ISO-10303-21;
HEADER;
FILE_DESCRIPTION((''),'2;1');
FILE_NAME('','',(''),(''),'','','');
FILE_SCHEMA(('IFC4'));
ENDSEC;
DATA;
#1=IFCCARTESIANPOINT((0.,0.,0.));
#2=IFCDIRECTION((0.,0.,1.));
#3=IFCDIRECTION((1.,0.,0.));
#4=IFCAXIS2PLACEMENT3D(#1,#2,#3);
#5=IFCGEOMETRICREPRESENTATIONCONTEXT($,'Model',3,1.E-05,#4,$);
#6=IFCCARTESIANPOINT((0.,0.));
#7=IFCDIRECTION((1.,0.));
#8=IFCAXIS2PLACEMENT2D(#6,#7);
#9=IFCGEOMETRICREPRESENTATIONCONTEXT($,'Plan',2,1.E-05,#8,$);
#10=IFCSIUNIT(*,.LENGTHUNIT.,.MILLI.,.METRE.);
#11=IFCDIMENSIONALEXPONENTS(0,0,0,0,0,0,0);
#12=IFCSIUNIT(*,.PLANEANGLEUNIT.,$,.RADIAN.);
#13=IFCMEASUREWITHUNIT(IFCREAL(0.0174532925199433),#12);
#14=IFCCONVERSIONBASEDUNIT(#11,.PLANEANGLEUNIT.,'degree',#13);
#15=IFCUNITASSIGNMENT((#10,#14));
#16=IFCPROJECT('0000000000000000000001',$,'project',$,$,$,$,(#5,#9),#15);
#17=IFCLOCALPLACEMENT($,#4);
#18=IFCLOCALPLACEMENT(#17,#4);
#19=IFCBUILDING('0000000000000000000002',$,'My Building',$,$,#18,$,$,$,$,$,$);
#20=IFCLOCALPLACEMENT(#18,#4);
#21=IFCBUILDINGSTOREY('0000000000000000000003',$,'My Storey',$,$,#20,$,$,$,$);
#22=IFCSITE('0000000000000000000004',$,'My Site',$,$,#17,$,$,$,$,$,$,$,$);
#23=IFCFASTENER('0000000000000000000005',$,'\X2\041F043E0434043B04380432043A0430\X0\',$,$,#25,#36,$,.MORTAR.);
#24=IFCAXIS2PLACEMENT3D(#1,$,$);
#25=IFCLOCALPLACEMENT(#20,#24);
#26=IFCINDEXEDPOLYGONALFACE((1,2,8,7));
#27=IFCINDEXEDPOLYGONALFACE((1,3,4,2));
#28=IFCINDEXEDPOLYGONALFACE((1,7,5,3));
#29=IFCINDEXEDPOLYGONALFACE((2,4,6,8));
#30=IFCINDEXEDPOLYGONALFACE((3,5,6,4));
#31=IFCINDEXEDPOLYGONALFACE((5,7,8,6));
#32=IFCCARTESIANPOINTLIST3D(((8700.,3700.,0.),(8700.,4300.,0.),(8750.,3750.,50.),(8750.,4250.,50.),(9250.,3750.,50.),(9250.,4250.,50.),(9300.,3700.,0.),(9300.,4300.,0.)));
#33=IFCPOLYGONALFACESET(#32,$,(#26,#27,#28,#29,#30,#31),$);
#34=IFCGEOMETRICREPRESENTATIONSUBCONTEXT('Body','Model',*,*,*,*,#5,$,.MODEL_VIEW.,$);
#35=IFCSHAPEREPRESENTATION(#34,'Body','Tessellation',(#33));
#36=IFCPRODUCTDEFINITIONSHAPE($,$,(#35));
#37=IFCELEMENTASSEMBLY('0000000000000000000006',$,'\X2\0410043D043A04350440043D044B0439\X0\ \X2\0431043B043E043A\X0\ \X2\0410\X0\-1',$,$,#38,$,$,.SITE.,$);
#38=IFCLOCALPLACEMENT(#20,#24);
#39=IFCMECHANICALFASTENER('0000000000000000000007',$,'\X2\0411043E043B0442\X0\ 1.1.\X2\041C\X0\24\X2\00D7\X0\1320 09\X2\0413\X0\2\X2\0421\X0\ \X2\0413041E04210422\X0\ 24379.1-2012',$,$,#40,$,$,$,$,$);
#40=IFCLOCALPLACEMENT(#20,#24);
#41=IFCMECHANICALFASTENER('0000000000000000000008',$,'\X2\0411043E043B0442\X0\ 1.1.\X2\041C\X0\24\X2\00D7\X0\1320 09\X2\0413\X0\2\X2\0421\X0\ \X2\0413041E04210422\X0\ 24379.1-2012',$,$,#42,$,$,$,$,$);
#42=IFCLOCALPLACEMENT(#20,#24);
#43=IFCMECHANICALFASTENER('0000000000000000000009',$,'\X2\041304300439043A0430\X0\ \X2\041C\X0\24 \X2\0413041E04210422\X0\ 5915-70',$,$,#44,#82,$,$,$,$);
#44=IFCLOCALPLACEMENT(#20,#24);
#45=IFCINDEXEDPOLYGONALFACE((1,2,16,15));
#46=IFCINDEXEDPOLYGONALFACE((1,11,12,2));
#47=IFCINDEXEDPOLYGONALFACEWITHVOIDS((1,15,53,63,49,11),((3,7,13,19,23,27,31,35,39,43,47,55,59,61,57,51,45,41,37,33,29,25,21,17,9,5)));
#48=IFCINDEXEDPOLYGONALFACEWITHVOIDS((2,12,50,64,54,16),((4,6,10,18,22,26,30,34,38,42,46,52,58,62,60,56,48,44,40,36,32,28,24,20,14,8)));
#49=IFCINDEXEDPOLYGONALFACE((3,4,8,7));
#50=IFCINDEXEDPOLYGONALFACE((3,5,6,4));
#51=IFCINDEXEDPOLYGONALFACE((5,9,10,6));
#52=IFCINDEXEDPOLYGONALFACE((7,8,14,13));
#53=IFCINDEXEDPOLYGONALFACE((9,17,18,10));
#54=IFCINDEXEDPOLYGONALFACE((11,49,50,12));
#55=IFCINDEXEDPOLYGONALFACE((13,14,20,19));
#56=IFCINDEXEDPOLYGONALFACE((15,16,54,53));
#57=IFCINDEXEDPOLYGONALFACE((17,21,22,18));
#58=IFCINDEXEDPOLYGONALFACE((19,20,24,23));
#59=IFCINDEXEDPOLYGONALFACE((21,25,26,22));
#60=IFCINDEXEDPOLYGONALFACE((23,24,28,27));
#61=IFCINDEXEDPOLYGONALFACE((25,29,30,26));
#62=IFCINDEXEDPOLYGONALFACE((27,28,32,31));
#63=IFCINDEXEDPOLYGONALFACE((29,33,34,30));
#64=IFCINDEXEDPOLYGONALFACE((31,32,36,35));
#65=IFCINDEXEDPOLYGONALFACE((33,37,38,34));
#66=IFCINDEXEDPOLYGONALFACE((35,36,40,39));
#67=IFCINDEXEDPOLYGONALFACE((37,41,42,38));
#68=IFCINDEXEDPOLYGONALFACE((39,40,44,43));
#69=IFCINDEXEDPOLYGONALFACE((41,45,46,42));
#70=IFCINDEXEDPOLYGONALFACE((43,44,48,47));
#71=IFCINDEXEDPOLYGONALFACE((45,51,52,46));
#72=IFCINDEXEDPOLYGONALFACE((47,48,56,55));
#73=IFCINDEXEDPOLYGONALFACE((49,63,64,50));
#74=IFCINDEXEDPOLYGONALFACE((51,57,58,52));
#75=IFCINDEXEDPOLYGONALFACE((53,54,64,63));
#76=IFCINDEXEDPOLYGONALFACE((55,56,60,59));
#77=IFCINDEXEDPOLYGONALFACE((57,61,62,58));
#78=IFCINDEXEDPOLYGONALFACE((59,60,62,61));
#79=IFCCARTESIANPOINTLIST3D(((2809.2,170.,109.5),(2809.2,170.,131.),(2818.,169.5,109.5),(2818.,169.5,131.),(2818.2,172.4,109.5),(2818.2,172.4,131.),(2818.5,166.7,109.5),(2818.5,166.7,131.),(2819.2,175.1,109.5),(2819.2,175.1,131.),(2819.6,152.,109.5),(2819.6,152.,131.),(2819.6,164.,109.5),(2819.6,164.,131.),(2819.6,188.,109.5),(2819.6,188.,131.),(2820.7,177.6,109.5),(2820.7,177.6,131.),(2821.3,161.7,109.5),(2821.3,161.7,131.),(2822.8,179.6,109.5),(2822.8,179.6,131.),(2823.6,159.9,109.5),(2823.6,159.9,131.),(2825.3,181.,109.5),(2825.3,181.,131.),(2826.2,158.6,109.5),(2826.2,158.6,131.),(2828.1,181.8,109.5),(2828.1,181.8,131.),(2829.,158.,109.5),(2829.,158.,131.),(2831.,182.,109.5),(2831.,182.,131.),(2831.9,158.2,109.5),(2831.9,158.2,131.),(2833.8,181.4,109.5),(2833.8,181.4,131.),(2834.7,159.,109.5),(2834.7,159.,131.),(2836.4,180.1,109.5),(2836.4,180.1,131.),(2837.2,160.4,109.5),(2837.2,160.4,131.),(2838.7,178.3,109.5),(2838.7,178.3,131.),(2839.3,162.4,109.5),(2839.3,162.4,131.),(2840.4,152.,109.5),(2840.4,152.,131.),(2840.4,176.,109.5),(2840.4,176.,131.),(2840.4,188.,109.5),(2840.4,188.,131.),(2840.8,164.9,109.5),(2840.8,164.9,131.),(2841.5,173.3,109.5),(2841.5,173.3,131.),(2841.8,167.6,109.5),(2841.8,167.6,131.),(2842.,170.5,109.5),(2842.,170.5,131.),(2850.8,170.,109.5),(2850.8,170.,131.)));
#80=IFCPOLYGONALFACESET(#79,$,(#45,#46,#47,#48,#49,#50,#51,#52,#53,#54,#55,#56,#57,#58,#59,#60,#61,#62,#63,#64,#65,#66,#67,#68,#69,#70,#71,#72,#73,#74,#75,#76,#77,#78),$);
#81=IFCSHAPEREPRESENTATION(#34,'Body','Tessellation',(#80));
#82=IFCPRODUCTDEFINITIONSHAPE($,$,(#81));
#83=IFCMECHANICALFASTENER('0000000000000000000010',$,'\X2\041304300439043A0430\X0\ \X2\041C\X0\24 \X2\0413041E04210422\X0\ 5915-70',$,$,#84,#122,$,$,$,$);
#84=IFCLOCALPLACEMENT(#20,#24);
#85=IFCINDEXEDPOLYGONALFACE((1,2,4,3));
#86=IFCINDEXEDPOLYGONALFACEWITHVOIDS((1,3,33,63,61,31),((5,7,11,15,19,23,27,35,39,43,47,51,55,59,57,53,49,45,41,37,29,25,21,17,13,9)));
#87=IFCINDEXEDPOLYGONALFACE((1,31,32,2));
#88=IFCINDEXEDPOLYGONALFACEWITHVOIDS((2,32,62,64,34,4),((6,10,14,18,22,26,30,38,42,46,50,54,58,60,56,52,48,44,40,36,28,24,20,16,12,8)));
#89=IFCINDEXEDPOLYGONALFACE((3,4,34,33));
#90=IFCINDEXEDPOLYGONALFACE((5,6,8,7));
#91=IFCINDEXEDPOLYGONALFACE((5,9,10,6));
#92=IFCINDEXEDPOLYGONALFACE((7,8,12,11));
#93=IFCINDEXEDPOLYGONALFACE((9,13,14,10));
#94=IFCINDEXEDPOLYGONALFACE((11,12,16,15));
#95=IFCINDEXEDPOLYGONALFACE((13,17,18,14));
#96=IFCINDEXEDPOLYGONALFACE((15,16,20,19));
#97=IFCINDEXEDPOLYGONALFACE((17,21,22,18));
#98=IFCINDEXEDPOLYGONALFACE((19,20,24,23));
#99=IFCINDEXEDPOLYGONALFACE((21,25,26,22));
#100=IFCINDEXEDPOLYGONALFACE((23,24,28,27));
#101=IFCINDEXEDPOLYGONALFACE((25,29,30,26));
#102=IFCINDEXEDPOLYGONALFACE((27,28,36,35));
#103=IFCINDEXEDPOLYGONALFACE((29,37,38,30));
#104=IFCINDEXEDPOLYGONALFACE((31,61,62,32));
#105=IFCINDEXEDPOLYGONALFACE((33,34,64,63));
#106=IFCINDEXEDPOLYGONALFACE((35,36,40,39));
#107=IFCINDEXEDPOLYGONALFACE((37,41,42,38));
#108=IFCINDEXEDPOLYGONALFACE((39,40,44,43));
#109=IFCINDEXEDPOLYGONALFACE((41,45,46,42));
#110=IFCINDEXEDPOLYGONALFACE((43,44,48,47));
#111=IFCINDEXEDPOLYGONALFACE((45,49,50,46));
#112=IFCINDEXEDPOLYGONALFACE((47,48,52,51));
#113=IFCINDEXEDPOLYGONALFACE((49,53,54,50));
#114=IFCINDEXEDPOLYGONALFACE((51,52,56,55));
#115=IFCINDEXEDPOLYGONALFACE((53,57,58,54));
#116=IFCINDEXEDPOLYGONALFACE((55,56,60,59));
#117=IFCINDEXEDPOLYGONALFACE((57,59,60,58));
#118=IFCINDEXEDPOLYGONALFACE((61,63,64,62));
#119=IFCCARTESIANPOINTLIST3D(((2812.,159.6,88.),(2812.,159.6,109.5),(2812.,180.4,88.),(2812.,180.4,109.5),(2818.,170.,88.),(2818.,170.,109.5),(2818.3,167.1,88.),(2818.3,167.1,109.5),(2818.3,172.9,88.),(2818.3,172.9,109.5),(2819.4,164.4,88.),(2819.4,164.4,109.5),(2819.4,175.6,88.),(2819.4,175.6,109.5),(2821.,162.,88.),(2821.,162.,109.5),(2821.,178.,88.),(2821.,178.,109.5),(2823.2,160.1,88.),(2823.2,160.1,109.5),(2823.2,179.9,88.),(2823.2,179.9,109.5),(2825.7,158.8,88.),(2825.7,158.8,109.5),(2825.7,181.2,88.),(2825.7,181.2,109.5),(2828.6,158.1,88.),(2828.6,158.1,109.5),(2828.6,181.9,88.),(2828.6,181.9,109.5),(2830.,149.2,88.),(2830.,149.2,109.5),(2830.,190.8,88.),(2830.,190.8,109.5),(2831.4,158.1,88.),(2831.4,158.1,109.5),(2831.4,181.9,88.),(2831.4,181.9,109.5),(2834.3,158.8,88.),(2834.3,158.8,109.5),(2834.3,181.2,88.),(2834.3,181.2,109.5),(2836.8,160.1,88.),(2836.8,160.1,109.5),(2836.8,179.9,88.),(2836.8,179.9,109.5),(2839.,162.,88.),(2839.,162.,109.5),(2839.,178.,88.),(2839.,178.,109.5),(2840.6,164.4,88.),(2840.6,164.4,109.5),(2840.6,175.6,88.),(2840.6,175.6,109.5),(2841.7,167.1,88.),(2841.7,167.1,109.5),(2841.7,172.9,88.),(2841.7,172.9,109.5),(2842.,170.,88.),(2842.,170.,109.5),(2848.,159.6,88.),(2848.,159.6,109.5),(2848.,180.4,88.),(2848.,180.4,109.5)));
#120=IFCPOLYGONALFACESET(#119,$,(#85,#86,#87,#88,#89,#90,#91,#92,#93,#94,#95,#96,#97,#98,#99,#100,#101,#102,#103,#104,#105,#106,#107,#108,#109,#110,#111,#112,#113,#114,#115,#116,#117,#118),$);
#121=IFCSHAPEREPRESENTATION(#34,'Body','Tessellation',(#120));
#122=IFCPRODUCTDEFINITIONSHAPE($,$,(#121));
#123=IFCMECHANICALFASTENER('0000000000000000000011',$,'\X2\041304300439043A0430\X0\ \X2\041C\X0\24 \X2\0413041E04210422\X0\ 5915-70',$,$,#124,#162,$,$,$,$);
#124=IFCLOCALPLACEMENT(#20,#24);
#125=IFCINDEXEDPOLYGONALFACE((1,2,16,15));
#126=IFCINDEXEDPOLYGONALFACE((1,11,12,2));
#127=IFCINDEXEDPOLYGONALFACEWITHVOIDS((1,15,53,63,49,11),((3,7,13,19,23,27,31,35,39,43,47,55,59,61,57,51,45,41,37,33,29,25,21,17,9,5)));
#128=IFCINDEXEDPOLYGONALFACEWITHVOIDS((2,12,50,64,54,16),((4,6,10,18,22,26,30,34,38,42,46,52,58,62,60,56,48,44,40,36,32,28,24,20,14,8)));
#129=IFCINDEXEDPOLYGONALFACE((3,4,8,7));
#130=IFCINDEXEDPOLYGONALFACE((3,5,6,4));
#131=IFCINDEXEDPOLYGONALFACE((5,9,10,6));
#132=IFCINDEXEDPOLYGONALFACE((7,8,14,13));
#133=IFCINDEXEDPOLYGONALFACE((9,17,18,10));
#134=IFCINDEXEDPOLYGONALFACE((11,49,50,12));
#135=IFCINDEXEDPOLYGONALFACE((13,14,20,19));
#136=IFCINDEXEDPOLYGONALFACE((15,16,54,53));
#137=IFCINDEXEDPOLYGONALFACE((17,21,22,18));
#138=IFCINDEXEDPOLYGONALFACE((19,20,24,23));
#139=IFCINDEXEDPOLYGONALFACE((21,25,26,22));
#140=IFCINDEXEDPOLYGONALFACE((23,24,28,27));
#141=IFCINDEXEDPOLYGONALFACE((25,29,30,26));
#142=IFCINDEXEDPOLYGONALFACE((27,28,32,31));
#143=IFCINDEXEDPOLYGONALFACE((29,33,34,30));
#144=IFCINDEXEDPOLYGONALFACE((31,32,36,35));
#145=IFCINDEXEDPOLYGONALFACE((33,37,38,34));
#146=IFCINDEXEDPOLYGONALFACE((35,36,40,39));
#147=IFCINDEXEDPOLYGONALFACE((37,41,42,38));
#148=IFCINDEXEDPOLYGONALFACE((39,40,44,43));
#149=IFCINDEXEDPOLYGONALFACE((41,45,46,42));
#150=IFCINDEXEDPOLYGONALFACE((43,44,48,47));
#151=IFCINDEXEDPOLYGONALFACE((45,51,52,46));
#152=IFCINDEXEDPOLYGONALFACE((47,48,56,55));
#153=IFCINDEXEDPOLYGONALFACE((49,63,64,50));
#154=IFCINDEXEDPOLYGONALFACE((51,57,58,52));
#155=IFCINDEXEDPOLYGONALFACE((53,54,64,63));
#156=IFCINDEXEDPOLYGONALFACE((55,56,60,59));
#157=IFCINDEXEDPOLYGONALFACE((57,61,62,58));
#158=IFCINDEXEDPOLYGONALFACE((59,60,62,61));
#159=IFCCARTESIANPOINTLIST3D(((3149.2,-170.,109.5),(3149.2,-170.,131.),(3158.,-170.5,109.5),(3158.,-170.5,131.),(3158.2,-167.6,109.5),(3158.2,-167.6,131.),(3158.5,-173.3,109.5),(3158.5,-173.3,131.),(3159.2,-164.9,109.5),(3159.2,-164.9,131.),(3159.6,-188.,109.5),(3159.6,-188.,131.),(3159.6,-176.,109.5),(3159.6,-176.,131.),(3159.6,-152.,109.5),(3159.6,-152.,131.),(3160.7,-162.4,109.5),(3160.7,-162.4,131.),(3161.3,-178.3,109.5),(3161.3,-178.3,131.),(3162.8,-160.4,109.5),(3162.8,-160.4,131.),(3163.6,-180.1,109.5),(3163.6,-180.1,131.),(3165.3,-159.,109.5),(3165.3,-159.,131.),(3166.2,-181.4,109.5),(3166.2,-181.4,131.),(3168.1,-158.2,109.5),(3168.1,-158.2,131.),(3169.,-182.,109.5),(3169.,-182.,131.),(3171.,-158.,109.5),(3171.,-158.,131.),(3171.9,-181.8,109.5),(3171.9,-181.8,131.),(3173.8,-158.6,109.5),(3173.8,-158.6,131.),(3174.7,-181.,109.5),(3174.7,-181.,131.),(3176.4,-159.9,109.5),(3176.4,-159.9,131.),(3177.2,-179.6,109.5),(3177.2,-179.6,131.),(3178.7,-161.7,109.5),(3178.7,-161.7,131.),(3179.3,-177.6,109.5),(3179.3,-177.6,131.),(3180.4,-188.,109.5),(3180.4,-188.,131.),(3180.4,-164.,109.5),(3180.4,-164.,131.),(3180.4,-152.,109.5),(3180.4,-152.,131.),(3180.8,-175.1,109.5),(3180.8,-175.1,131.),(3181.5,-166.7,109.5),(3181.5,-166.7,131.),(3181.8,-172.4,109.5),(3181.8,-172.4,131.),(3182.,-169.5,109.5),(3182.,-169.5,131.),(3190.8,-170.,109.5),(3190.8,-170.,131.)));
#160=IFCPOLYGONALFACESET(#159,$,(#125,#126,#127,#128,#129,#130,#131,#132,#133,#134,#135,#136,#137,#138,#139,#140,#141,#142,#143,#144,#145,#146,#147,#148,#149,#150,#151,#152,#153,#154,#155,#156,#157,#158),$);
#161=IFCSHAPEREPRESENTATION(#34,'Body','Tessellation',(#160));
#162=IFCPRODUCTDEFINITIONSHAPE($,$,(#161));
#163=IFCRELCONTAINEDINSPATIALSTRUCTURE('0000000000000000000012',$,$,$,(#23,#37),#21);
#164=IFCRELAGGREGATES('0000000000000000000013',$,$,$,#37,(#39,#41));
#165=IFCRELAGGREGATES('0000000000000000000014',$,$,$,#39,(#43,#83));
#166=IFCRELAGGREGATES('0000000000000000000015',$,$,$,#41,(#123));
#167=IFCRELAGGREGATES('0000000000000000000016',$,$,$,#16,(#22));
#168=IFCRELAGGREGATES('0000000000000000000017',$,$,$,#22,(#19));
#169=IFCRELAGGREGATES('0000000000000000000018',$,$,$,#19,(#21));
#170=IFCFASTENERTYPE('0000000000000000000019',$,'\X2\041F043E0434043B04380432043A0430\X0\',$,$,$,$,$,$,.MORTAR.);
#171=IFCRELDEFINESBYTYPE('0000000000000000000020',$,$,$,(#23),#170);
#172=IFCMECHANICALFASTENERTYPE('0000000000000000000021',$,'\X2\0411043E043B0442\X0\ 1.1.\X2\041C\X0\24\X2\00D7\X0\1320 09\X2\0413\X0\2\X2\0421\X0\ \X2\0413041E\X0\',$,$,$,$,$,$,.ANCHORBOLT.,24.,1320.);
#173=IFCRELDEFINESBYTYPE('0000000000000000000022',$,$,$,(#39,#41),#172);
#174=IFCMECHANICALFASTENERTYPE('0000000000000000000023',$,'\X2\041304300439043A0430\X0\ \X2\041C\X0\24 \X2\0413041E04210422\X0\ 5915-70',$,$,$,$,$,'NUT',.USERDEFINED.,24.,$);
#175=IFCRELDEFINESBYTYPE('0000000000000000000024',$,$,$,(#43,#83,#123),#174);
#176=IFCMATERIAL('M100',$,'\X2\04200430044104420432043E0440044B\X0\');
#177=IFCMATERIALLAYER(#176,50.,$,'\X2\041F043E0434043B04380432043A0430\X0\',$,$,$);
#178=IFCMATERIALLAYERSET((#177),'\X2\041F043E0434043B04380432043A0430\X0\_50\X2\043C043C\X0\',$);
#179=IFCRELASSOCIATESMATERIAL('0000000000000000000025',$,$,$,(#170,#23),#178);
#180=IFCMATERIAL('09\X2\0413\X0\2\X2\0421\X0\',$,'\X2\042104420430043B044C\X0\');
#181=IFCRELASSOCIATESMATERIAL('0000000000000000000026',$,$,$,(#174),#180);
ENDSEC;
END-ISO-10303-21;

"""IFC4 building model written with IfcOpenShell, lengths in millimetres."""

from ifc_helpers import new_model, entity, si_unit, converted_unit, frame, origin_with_axes, origin_2d_with_axis, place, context, subcontext, project, spatial, polyline, line, indexed_curve, outline, extrude, clip, halfspace, source, transform, mapped, material, layer, layer_set, layer_usage, type_object, type_shapes, element, aggregate, save


model = new_model("IFC4")

# Units and contexts
model_context = context("Model", 3, precision=1e-05, world=origin_with_axes())
plan_context = context("Plan", 2, precision=1e-05, world=origin_2d_with_axis())
body_context = subcontext(model_context, "Body", "Model", "MODEL_VIEW")
ifc_project = project(units=[si_unit("LENGTHUNIT", "METRE", prefix="MILLI"), converted_unit("PLANEANGLEUNIT", "degree", entity("IfcReal", 0.0174532925199433), si_unit("PLANEANGLEUNIT", "RADIAN"), dimensions=[0, 0, 0, 0, 0, 0, 0])], contexts=[model_context, plan_context])

# Site, building, storey
site_placement = place(None, origin_with_axes())
site = spatial("IfcSite", under=ifc_project, at=site_placement, Name="My Site")
building_placement = place(site_placement, origin_with_axes())
building = spatial("IfcBuilding", under=site, at=building_placement, Name="My Building")
storey_placement = place(building_placement, origin_with_axes())
storey = spatial("IfcBuildingStorey", under=building, at=storey_placement, Name="My Storey")

# Fastener
ifc_material_1 = material(Name="M100", Category="Растворы")
ifc_layer_1 = layer(ifc_material_1, 50.0, Name="Подливка")
ifc_layer_set_1 = layer_set([ifc_layer_1], Name="Подливка_50мм")
ifc_layer_usage_1 = layer_usage(ifc_layer_set_1, "AXIS3", "POSITIVE", 0.0)
fastener_type = type_object("IfcFastenerType", Name="Подливка", PredefinedType="MORTAR", material=ifc_layer_set_1)
placement = place(storey_placement, frame((3000.0, 0.0, 0.0), z_axis=(0.0, 0.0, 1.0), x_axis=(1.0, 0.0, 0.0)))
fastener_1_placement = place(storey_placement, frame((9000.0, 4000.0, 0.0), z_axis=(0.0, 0.0, 1.0), x_axis=(1.0, 0.0, 0.0)))
element("IfcFastener", 1, at=fastener_1_placement, inside=storey, type_object=fastener_type, material=ifc_layer_usage_1, Name="Подливка", PredefinedType="MORTAR", context=body_context, shape_type="Clipping", body=[
    clip(clip(clip(clip(extrude(outline(indexed_curve([(-300.0, -300.0), (300.0, -300.0), (300.0, 300.0), (-300.0, 300.0)], segments=[line(3, 2), line(2, 1), line(1, 4), line(4, 3)], self_intersect=False)), None, (0.0, 0.0, 1.0), 50.0), halfspace(frame((-53.6, 200.0, 353.6), z_axis=(0.707107, 0.0, 0.707107), x_axis=(0.707107, 0.0, -0.707107)), False)), halfspace(frame((-200.0, -53.6, 353.6), z_axis=(0.0, 0.707107, 0.707107), x_axis=(0.0, 0.707107, -0.707107)), False)), halfspace(frame((200.0, 53.6, 353.6), z_axis=(0.0, -0.707107, 0.707107), x_axis=(0.0, -0.707107, -0.707107)), False)), halfspace(frame((53.6, 200.0, 353.6), z_axis=(-0.707107, 0.0, 0.707107), x_axis=(-0.707107, 0.0, -0.707107)), False)),
])

# Element assembly, mechanical fasteners
assembly = element("IfcElementAssembly", 2, at=placement, inside=storey, Name="Анкерный блок А-1", AssemblyPlace="SITE")
mechanical_fastener_type_1 = type_object("IfcMechanicalFastenerType", Name="Болт 1.1.М24×1320 09Г2С ГО", NominalDiameter=24.0, NominalLength=1320.0, PredefinedType="ANCHORBOLT")
mechanical_fastener_1_placement = place(placement, frame((-170.0, 170.0, 0.0), z_axis=(0.0, 0.0, 1.0), x_axis=(-1.0, 0.0, 0.0)))
mechanical_fastener_1 = element("IfcMechanicalFastener", 3, at=mechanical_fastener_1_placement, type_object=mechanical_fastener_type_1, Name="Болт 1.1.М24×1320 09Г2С ГОСТ 24379.1-2012")
ifc_material_2 = material(Name="09Г2С", Category="Сталь")
mechanical_fastener_2_placement = place(placement, frame((170.0, -170.0, 0.0), z_axis=(0.0, 0.0, 1.0), x_axis=(1.0, 0.0, 0.0)))
mechanical_fastener_2 = element("IfcMechanicalFastener", 4, at=mechanical_fastener_2_placement, type_object=mechanical_fastener_type_1, Name="Болт 1.1.М24×1320 09Г2С ГОСТ 24379.1-2012")
aggregate(assembly, [mechanical_fastener_1, mechanical_fastener_2])
mechanical_fastener_type_2 = type_object("IfcMechanicalFastenerType", Name="Гайка М24 ГОСТ 5915-70", ElementType="NUT", NominalDiameter=24.0, PredefinedType="USERDEFINED", material=ifc_material_2)
shared_shape_1 = source(origin_with_axes(), body_context, "Body", "SweptSolid", [
    extrude(outline(polyline([(-10.4, -18.0), (10.4, -18.0), (20.8, 0.0), (10.4, 18.0), (-10.4, 18.0), (-20.8, 0.0), (-10.4, -18.0)]), holes=[polyline([(-8.0, 9.0), (-5.6, 10.6), (-2.9, 11.7), (0.0, 12.0), (2.9, 11.7), (5.6, 10.6), (8.0, 9.0), (9.9, 6.8), (11.2, 4.3), (11.9, 1.4), (11.9, -1.4), (11.2, -4.3), (9.9, -6.8), (8.0, -9.0), (5.6, -10.6), (2.9, -11.7), (0.0, -12.0), (-2.9, -11.7), (-5.6, -10.6), (-8.0, -9.0), (-9.9, -6.8), (-11.2, -4.3), (-11.9, -1.4), (-11.9, 1.4), (-11.2, 4.3), (-9.9, 6.8), (-8.0, 9.0)])]), frame((0.0, 0.0, 0.0), z_axis=(0.0, 0.0, 1.0), x_axis=(0.0, 1.0, 0.0)), (0.0, 0.0, 1.0), 21.5),
])
type_shapes(mechanical_fastener_type_2, [shared_shape_1])
mechanical_fastener_3_placement = place(mechanical_fastener_1_placement, frame((0.0, 0.0, 109.5), z_axis=(0.0, 0.0, 1.0), x_axis=(0.866025, 0.5, 0.0)))
mechanical_fastener_3 = element("IfcMechanicalFastener", 5, at=mechanical_fastener_3_placement, type_object=mechanical_fastener_type_2, Name="Гайка М24 ГОСТ 5915-70", context=body_context, shape_type="MappedRepresentation", body=[
    mapped(shared_shape_1, transform((0.0, 0.0, 0.0), x_axis=(1.0, 0.0, 0.0), y_axis=(0.0, 1.0, 0.0), z_axis=(0.0, 0.0, 1.0), scale=1.0)),
])
mechanical_fastener_4_placement = place(mechanical_fastener_1_placement, frame((0.0, 0.0, 88.0), z_axis=(0.0, 0.0, 1.0), x_axis=(1.0, 0.0, 0.0)))
mechanical_fastener_4 = element("IfcMechanicalFastener", 6, at=mechanical_fastener_4_placement, type_object=mechanical_fastener_type_2, Name="Гайка М24 ГОСТ 5915-70", context=body_context, shape_type="MappedRepresentation", body=[
    mapped(shared_shape_1, transform((0.0, 0.0, 0.0), x_axis=(1.0, 0.0, 0.0), y_axis=(0.0, 1.0, 0.0), z_axis=(0.0, 0.0, 1.0), scale=1.0)),
])
mechanical_fastener_5_placement = place(mechanical_fastener_2_placement, frame((0.0, 0.0, 109.5), z_axis=(0.0, 0.0, 1.0), x_axis=(0.866025, 0.5, 0.0)))
mechanical_fastener_5 = element("IfcMechanicalFastener", 7, at=mechanical_fastener_5_placement, type_object=mechanical_fastener_type_2, Name="Гайка М24 ГОСТ 5915-70", context=body_context, shape_type="MappedRepresentation", body=[
    mapped(shared_shape_1, transform((0.0, 0.0, 0.0), x_axis=(1.0, 0.0, 0.0), y_axis=(0.0, 1.0, 0.0), z_axis=(0.0, 0.0, 1.0), scale=1.0)),
])
aggregate(mechanical_fastener_1, [mechanical_fastener_3, mechanical_fastener_4])
aggregate(mechanical_fastener_2, [mechanical_fastener_5])

save(model, "model.ifc")
